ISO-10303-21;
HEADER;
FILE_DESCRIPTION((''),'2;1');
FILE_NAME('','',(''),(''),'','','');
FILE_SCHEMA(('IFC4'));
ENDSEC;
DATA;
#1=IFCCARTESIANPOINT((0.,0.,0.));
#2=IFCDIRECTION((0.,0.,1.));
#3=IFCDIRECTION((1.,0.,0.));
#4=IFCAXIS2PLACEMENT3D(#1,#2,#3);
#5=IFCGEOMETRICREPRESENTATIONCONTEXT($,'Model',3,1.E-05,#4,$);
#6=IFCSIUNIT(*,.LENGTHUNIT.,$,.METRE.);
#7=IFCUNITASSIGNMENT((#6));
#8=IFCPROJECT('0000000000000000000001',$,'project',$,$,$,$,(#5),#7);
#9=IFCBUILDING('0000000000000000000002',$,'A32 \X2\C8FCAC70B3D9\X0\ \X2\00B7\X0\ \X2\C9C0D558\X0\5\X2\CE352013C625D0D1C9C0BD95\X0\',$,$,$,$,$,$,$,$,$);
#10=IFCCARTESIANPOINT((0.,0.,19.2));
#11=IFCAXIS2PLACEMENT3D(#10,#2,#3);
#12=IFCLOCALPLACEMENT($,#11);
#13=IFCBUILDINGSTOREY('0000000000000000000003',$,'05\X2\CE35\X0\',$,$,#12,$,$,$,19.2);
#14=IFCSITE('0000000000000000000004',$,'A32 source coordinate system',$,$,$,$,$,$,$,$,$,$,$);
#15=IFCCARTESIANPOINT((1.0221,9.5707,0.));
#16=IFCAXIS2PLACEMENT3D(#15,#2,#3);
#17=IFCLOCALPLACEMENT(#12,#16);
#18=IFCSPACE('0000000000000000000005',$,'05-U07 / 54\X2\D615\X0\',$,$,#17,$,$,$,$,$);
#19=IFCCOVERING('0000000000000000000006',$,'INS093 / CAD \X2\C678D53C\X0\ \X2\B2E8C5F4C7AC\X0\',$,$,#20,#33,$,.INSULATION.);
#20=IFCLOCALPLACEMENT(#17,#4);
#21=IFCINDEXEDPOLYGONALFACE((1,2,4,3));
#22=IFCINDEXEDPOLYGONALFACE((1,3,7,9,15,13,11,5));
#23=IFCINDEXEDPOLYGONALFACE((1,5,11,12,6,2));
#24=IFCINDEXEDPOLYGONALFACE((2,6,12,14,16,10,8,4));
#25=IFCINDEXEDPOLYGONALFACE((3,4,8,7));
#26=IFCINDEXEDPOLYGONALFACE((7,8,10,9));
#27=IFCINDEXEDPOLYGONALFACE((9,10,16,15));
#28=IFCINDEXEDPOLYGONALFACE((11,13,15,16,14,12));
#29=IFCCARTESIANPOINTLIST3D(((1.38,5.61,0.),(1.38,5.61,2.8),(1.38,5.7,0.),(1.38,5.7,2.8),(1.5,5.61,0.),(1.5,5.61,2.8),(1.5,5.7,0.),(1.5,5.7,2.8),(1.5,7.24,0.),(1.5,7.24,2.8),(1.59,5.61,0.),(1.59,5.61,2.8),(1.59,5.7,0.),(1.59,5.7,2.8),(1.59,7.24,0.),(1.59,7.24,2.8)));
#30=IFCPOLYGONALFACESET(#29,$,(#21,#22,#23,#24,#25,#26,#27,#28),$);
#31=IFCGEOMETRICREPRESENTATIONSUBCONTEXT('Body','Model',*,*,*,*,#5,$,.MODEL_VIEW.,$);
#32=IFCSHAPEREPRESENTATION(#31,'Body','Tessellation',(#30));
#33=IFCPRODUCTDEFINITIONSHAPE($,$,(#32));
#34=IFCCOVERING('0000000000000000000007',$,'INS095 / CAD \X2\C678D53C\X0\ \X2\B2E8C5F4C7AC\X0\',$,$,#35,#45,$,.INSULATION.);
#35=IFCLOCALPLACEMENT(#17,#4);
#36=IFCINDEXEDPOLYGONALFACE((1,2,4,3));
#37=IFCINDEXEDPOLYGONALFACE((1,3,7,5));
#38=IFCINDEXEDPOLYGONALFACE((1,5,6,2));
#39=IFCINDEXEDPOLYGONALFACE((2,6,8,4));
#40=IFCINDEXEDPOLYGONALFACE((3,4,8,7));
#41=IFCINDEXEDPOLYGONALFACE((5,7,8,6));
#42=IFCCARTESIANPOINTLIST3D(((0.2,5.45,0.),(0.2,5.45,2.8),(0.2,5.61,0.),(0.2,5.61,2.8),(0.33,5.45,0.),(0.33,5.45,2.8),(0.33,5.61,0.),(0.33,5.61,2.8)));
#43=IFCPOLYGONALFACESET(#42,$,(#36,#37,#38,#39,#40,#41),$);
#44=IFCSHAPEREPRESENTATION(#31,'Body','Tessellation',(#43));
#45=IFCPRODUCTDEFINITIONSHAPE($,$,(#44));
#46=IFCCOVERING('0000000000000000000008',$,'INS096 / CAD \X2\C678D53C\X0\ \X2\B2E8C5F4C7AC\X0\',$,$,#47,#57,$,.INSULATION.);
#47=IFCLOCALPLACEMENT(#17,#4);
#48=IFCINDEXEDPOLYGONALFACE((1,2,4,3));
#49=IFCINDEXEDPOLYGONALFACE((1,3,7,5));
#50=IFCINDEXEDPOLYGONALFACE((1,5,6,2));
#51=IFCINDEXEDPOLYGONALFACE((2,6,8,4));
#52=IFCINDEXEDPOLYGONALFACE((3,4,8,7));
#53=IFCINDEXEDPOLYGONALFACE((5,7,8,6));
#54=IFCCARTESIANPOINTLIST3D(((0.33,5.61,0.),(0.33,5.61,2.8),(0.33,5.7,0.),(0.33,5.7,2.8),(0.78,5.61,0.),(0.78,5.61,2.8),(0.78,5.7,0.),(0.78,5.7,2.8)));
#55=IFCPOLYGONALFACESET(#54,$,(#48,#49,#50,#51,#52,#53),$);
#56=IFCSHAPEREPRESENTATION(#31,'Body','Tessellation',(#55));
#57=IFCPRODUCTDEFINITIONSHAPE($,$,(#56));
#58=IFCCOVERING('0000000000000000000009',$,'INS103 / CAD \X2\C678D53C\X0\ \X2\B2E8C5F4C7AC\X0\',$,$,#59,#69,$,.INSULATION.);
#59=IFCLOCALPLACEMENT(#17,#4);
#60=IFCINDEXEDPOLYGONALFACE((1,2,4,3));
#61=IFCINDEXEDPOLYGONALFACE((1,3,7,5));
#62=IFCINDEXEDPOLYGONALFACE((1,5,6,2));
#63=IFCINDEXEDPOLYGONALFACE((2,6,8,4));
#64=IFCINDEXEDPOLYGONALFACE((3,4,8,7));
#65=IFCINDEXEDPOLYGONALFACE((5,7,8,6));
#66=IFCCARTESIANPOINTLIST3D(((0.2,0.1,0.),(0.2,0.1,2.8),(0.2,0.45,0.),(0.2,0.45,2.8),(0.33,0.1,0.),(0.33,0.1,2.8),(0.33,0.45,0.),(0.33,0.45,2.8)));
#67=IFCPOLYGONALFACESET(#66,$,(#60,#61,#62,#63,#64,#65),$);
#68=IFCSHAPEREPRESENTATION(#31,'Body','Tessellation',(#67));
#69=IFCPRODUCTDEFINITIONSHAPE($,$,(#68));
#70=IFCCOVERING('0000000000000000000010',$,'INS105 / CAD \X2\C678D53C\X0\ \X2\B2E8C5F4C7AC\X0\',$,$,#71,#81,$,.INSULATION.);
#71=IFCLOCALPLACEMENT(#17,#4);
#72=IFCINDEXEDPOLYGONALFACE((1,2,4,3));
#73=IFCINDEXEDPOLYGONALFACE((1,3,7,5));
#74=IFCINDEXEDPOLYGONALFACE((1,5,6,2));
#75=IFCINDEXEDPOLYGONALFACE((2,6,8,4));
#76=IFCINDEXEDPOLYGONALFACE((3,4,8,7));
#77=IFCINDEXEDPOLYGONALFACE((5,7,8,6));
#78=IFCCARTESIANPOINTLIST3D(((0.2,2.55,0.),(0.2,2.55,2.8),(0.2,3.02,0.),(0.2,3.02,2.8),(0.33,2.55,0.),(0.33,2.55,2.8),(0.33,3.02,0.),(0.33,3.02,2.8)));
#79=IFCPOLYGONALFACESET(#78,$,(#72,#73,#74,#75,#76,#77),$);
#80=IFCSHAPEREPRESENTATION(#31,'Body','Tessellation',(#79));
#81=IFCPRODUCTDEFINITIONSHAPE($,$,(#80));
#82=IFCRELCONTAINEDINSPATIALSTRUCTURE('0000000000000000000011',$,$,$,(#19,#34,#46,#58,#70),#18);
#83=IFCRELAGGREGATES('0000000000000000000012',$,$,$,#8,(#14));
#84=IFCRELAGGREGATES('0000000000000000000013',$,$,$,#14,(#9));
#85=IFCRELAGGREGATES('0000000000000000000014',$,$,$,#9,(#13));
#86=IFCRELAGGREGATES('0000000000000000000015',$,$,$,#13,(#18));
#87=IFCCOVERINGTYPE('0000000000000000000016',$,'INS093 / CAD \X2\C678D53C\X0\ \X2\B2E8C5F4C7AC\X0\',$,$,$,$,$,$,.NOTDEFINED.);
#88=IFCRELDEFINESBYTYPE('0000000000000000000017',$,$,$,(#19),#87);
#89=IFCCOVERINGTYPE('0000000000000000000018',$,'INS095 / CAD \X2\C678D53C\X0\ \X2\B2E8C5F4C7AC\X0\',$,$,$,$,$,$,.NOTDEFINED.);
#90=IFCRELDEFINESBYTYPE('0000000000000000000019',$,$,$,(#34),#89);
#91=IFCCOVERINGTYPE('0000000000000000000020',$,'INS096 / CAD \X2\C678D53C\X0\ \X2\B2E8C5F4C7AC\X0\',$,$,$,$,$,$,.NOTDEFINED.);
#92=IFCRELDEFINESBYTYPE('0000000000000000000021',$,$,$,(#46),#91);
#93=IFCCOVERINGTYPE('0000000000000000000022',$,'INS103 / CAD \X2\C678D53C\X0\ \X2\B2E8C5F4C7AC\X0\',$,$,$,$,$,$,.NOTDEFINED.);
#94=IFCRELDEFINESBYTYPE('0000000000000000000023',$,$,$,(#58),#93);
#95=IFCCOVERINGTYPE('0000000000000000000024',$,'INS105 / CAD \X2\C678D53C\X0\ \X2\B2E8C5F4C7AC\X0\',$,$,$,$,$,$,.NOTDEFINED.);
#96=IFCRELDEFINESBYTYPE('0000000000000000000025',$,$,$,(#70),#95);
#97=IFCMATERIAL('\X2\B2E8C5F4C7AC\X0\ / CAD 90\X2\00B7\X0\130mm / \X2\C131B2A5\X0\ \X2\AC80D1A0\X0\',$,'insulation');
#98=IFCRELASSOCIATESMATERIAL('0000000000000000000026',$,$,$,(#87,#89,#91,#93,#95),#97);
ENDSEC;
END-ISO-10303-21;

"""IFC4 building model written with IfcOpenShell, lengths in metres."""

from ifc_helpers import new_model, si_unit, frame, origin, origin_with_axes, place, context, subcontext, project, spatial, polyline, outline, extrude, source, transform, mapped, material, type_object, type_shapes, element, save


model = new_model("IFC4")

# Units and contexts
model_context = context("Model", 3, precision=1e-05, world=origin_with_axes())
body_context = subcontext(model_context, "Body", "Model", "MODEL_VIEW")
ifc_project = project(units=[si_unit("LENGTHUNIT", "METRE")], contexts=[model_context])

# Site, building, storey, space
storey_placement = place(None, frame((0.0, 0.0, 19.2), z_axis=(0.0, 0.0, 1.0), x_axis=(1.0, 0.0, 0.0)))
space_placement = place(storey_placement, frame((1.0221, 9.5707, 0.0), z_axis=(0.0, 0.0, 1.0), x_axis=(1.0, 0.0, 0.0)))
site = spatial("IfcSite", under=ifc_project, Name="A32 source coordinate system")
building = spatial("IfcBuilding", under=site, Name="A32 주거동 · 지하5층–옥탑지붕")
storey = spatial("IfcBuildingStorey", under=building, at=storey_placement, Name="05층", Elevation=19.2)
space = spatial("IfcSpace", under=storey, at=space_placement, Name="05-U07 / 54형")

# Coverings
ifc_material = material(Name="단열재 / CAD 90·130mm / 성능 검토", Category="insulation")
covering_type_1 = type_object("IfcCoveringType", Name="INS093 / CAD 외피 단열재", PredefinedType="NOTDEFINED", material=ifc_material)
shared_shape_1 = source(origin(), body_context, "Body", "SweptSolid", [
    extrude(outline(polyline([(1.5, 5.7), (1.5, 7.24), (1.59, 7.24), (1.59, 5.7), (1.59, 5.61), (1.5, 5.61), (1.38, 5.61), (1.38, 5.7), (1.5, 5.7)])), origin(), (0.0, 0.0, 1.0), 2.8),
])
type_shapes(covering_type_1, [shared_shape_1])
covering_1_placement = place(space_placement, origin_with_axes())
element("IfcCovering", 1, at=covering_1_placement, inside=space, type_object=covering_type_1, Name="INS093 / CAD 외피 단열재", PredefinedType="INSULATION", context=body_context, shape_type="MappedRepresentation", body=[
    mapped(shared_shape_1, transform((0.0, 0.0, 0.0), scale=1.0)),
])
covering_type_2 = type_object("IfcCoveringType", Name="INS095 / CAD 외피 단열재", PredefinedType="NOTDEFINED", material=ifc_material)
shared_shape_2 = source(origin(), body_context, "Body", "SweptSolid", [
    extrude(outline(polyline([(0.2, 5.61), (0.33, 5.61), (0.33, 5.45), (0.2, 5.45), (0.2, 5.61)])), origin(), (0.0, 0.0, 1.0), 2.8),
])
type_shapes(covering_type_2, [shared_shape_2])
covering_2_placement = place(space_placement, origin_with_axes())
element("IfcCovering", 2, at=covering_2_placement, inside=space, type_object=covering_type_2, Name="INS095 / CAD 외피 단열재", PredefinedType="INSULATION", context=body_context, shape_type="MappedRepresentation", body=[
    mapped(shared_shape_2, transform((0.0, 0.0, 0.0), scale=1.0)),
])
covering_type_3 = type_object("IfcCoveringType", Name="INS096 / CAD 외피 단열재", PredefinedType="NOTDEFINED", material=ifc_material)
shared_shape_3 = source(origin(), body_context, "Body", "SweptSolid", [
    extrude(outline(polyline([(0.78, 5.7), (0.78, 5.61), (0.33, 5.61), (0.33, 5.7), (0.78, 5.7)])), origin(), (0.0, 0.0, 1.0), 2.8),
])
type_shapes(covering_type_3, [shared_shape_3])
covering_3_placement = place(space_placement, origin_with_axes())
element("IfcCovering", 3, at=covering_3_placement, inside=space, type_object=covering_type_3, Name="INS096 / CAD 외피 단열재", PredefinedType="INSULATION", context=body_context, shape_type="MappedRepresentation", body=[
    mapped(shared_shape_3, transform((0.0, 0.0, 0.0), scale=1.0)),
])
covering_type_4 = type_object("IfcCoveringType", Name="INS103 / CAD 외피 단열재", PredefinedType="NOTDEFINED", material=ifc_material)
shared_shape_4 = source(origin(), body_context, "Body", "SweptSolid", [
    extrude(outline(polyline([(0.2, 0.45), (0.33, 0.45), (0.33, 0.1), (0.2, 0.1), (0.2, 0.45)])), origin(), (0.0, 0.0, 1.0), 2.8),
])
type_shapes(covering_type_4, [shared_shape_4])
covering_4_placement = place(space_placement, origin_with_axes())
element("IfcCovering", 4, at=covering_4_placement, inside=space, type_object=covering_type_4, Name="INS103 / CAD 외피 단열재", PredefinedType="INSULATION", context=body_context, shape_type="MappedRepresentation", body=[
    mapped(shared_shape_4, transform((0.0, 0.0, 0.0), scale=1.0)),
])
covering_type_5 = type_object("IfcCoveringType", Name="INS105 / CAD 외피 단열재", PredefinedType="NOTDEFINED", material=ifc_material)
shared_shape_5 = source(origin(), body_context, "Body", "SweptSolid", [
    extrude(outline(polyline([(0.2, 3.02), (0.33, 3.02), (0.33, 2.55), (0.2, 2.55), (0.2, 3.02)])), origin(), (0.0, 0.0, 1.0), 2.8),
])
type_shapes(covering_type_5, [shared_shape_5])
covering_5_placement = place(space_placement, origin_with_axes())
element("IfcCovering", 5, at=covering_5_placement, inside=space, type_object=covering_type_5, Name="INS105 / CAD 외피 단열재", PredefinedType="INSULATION", context=body_context, shape_type="MappedRepresentation", body=[
    mapped(shared_shape_5, transform((0.0, 0.0, 0.0), scale=1.0)),
])

save(model, "model.ifc")
